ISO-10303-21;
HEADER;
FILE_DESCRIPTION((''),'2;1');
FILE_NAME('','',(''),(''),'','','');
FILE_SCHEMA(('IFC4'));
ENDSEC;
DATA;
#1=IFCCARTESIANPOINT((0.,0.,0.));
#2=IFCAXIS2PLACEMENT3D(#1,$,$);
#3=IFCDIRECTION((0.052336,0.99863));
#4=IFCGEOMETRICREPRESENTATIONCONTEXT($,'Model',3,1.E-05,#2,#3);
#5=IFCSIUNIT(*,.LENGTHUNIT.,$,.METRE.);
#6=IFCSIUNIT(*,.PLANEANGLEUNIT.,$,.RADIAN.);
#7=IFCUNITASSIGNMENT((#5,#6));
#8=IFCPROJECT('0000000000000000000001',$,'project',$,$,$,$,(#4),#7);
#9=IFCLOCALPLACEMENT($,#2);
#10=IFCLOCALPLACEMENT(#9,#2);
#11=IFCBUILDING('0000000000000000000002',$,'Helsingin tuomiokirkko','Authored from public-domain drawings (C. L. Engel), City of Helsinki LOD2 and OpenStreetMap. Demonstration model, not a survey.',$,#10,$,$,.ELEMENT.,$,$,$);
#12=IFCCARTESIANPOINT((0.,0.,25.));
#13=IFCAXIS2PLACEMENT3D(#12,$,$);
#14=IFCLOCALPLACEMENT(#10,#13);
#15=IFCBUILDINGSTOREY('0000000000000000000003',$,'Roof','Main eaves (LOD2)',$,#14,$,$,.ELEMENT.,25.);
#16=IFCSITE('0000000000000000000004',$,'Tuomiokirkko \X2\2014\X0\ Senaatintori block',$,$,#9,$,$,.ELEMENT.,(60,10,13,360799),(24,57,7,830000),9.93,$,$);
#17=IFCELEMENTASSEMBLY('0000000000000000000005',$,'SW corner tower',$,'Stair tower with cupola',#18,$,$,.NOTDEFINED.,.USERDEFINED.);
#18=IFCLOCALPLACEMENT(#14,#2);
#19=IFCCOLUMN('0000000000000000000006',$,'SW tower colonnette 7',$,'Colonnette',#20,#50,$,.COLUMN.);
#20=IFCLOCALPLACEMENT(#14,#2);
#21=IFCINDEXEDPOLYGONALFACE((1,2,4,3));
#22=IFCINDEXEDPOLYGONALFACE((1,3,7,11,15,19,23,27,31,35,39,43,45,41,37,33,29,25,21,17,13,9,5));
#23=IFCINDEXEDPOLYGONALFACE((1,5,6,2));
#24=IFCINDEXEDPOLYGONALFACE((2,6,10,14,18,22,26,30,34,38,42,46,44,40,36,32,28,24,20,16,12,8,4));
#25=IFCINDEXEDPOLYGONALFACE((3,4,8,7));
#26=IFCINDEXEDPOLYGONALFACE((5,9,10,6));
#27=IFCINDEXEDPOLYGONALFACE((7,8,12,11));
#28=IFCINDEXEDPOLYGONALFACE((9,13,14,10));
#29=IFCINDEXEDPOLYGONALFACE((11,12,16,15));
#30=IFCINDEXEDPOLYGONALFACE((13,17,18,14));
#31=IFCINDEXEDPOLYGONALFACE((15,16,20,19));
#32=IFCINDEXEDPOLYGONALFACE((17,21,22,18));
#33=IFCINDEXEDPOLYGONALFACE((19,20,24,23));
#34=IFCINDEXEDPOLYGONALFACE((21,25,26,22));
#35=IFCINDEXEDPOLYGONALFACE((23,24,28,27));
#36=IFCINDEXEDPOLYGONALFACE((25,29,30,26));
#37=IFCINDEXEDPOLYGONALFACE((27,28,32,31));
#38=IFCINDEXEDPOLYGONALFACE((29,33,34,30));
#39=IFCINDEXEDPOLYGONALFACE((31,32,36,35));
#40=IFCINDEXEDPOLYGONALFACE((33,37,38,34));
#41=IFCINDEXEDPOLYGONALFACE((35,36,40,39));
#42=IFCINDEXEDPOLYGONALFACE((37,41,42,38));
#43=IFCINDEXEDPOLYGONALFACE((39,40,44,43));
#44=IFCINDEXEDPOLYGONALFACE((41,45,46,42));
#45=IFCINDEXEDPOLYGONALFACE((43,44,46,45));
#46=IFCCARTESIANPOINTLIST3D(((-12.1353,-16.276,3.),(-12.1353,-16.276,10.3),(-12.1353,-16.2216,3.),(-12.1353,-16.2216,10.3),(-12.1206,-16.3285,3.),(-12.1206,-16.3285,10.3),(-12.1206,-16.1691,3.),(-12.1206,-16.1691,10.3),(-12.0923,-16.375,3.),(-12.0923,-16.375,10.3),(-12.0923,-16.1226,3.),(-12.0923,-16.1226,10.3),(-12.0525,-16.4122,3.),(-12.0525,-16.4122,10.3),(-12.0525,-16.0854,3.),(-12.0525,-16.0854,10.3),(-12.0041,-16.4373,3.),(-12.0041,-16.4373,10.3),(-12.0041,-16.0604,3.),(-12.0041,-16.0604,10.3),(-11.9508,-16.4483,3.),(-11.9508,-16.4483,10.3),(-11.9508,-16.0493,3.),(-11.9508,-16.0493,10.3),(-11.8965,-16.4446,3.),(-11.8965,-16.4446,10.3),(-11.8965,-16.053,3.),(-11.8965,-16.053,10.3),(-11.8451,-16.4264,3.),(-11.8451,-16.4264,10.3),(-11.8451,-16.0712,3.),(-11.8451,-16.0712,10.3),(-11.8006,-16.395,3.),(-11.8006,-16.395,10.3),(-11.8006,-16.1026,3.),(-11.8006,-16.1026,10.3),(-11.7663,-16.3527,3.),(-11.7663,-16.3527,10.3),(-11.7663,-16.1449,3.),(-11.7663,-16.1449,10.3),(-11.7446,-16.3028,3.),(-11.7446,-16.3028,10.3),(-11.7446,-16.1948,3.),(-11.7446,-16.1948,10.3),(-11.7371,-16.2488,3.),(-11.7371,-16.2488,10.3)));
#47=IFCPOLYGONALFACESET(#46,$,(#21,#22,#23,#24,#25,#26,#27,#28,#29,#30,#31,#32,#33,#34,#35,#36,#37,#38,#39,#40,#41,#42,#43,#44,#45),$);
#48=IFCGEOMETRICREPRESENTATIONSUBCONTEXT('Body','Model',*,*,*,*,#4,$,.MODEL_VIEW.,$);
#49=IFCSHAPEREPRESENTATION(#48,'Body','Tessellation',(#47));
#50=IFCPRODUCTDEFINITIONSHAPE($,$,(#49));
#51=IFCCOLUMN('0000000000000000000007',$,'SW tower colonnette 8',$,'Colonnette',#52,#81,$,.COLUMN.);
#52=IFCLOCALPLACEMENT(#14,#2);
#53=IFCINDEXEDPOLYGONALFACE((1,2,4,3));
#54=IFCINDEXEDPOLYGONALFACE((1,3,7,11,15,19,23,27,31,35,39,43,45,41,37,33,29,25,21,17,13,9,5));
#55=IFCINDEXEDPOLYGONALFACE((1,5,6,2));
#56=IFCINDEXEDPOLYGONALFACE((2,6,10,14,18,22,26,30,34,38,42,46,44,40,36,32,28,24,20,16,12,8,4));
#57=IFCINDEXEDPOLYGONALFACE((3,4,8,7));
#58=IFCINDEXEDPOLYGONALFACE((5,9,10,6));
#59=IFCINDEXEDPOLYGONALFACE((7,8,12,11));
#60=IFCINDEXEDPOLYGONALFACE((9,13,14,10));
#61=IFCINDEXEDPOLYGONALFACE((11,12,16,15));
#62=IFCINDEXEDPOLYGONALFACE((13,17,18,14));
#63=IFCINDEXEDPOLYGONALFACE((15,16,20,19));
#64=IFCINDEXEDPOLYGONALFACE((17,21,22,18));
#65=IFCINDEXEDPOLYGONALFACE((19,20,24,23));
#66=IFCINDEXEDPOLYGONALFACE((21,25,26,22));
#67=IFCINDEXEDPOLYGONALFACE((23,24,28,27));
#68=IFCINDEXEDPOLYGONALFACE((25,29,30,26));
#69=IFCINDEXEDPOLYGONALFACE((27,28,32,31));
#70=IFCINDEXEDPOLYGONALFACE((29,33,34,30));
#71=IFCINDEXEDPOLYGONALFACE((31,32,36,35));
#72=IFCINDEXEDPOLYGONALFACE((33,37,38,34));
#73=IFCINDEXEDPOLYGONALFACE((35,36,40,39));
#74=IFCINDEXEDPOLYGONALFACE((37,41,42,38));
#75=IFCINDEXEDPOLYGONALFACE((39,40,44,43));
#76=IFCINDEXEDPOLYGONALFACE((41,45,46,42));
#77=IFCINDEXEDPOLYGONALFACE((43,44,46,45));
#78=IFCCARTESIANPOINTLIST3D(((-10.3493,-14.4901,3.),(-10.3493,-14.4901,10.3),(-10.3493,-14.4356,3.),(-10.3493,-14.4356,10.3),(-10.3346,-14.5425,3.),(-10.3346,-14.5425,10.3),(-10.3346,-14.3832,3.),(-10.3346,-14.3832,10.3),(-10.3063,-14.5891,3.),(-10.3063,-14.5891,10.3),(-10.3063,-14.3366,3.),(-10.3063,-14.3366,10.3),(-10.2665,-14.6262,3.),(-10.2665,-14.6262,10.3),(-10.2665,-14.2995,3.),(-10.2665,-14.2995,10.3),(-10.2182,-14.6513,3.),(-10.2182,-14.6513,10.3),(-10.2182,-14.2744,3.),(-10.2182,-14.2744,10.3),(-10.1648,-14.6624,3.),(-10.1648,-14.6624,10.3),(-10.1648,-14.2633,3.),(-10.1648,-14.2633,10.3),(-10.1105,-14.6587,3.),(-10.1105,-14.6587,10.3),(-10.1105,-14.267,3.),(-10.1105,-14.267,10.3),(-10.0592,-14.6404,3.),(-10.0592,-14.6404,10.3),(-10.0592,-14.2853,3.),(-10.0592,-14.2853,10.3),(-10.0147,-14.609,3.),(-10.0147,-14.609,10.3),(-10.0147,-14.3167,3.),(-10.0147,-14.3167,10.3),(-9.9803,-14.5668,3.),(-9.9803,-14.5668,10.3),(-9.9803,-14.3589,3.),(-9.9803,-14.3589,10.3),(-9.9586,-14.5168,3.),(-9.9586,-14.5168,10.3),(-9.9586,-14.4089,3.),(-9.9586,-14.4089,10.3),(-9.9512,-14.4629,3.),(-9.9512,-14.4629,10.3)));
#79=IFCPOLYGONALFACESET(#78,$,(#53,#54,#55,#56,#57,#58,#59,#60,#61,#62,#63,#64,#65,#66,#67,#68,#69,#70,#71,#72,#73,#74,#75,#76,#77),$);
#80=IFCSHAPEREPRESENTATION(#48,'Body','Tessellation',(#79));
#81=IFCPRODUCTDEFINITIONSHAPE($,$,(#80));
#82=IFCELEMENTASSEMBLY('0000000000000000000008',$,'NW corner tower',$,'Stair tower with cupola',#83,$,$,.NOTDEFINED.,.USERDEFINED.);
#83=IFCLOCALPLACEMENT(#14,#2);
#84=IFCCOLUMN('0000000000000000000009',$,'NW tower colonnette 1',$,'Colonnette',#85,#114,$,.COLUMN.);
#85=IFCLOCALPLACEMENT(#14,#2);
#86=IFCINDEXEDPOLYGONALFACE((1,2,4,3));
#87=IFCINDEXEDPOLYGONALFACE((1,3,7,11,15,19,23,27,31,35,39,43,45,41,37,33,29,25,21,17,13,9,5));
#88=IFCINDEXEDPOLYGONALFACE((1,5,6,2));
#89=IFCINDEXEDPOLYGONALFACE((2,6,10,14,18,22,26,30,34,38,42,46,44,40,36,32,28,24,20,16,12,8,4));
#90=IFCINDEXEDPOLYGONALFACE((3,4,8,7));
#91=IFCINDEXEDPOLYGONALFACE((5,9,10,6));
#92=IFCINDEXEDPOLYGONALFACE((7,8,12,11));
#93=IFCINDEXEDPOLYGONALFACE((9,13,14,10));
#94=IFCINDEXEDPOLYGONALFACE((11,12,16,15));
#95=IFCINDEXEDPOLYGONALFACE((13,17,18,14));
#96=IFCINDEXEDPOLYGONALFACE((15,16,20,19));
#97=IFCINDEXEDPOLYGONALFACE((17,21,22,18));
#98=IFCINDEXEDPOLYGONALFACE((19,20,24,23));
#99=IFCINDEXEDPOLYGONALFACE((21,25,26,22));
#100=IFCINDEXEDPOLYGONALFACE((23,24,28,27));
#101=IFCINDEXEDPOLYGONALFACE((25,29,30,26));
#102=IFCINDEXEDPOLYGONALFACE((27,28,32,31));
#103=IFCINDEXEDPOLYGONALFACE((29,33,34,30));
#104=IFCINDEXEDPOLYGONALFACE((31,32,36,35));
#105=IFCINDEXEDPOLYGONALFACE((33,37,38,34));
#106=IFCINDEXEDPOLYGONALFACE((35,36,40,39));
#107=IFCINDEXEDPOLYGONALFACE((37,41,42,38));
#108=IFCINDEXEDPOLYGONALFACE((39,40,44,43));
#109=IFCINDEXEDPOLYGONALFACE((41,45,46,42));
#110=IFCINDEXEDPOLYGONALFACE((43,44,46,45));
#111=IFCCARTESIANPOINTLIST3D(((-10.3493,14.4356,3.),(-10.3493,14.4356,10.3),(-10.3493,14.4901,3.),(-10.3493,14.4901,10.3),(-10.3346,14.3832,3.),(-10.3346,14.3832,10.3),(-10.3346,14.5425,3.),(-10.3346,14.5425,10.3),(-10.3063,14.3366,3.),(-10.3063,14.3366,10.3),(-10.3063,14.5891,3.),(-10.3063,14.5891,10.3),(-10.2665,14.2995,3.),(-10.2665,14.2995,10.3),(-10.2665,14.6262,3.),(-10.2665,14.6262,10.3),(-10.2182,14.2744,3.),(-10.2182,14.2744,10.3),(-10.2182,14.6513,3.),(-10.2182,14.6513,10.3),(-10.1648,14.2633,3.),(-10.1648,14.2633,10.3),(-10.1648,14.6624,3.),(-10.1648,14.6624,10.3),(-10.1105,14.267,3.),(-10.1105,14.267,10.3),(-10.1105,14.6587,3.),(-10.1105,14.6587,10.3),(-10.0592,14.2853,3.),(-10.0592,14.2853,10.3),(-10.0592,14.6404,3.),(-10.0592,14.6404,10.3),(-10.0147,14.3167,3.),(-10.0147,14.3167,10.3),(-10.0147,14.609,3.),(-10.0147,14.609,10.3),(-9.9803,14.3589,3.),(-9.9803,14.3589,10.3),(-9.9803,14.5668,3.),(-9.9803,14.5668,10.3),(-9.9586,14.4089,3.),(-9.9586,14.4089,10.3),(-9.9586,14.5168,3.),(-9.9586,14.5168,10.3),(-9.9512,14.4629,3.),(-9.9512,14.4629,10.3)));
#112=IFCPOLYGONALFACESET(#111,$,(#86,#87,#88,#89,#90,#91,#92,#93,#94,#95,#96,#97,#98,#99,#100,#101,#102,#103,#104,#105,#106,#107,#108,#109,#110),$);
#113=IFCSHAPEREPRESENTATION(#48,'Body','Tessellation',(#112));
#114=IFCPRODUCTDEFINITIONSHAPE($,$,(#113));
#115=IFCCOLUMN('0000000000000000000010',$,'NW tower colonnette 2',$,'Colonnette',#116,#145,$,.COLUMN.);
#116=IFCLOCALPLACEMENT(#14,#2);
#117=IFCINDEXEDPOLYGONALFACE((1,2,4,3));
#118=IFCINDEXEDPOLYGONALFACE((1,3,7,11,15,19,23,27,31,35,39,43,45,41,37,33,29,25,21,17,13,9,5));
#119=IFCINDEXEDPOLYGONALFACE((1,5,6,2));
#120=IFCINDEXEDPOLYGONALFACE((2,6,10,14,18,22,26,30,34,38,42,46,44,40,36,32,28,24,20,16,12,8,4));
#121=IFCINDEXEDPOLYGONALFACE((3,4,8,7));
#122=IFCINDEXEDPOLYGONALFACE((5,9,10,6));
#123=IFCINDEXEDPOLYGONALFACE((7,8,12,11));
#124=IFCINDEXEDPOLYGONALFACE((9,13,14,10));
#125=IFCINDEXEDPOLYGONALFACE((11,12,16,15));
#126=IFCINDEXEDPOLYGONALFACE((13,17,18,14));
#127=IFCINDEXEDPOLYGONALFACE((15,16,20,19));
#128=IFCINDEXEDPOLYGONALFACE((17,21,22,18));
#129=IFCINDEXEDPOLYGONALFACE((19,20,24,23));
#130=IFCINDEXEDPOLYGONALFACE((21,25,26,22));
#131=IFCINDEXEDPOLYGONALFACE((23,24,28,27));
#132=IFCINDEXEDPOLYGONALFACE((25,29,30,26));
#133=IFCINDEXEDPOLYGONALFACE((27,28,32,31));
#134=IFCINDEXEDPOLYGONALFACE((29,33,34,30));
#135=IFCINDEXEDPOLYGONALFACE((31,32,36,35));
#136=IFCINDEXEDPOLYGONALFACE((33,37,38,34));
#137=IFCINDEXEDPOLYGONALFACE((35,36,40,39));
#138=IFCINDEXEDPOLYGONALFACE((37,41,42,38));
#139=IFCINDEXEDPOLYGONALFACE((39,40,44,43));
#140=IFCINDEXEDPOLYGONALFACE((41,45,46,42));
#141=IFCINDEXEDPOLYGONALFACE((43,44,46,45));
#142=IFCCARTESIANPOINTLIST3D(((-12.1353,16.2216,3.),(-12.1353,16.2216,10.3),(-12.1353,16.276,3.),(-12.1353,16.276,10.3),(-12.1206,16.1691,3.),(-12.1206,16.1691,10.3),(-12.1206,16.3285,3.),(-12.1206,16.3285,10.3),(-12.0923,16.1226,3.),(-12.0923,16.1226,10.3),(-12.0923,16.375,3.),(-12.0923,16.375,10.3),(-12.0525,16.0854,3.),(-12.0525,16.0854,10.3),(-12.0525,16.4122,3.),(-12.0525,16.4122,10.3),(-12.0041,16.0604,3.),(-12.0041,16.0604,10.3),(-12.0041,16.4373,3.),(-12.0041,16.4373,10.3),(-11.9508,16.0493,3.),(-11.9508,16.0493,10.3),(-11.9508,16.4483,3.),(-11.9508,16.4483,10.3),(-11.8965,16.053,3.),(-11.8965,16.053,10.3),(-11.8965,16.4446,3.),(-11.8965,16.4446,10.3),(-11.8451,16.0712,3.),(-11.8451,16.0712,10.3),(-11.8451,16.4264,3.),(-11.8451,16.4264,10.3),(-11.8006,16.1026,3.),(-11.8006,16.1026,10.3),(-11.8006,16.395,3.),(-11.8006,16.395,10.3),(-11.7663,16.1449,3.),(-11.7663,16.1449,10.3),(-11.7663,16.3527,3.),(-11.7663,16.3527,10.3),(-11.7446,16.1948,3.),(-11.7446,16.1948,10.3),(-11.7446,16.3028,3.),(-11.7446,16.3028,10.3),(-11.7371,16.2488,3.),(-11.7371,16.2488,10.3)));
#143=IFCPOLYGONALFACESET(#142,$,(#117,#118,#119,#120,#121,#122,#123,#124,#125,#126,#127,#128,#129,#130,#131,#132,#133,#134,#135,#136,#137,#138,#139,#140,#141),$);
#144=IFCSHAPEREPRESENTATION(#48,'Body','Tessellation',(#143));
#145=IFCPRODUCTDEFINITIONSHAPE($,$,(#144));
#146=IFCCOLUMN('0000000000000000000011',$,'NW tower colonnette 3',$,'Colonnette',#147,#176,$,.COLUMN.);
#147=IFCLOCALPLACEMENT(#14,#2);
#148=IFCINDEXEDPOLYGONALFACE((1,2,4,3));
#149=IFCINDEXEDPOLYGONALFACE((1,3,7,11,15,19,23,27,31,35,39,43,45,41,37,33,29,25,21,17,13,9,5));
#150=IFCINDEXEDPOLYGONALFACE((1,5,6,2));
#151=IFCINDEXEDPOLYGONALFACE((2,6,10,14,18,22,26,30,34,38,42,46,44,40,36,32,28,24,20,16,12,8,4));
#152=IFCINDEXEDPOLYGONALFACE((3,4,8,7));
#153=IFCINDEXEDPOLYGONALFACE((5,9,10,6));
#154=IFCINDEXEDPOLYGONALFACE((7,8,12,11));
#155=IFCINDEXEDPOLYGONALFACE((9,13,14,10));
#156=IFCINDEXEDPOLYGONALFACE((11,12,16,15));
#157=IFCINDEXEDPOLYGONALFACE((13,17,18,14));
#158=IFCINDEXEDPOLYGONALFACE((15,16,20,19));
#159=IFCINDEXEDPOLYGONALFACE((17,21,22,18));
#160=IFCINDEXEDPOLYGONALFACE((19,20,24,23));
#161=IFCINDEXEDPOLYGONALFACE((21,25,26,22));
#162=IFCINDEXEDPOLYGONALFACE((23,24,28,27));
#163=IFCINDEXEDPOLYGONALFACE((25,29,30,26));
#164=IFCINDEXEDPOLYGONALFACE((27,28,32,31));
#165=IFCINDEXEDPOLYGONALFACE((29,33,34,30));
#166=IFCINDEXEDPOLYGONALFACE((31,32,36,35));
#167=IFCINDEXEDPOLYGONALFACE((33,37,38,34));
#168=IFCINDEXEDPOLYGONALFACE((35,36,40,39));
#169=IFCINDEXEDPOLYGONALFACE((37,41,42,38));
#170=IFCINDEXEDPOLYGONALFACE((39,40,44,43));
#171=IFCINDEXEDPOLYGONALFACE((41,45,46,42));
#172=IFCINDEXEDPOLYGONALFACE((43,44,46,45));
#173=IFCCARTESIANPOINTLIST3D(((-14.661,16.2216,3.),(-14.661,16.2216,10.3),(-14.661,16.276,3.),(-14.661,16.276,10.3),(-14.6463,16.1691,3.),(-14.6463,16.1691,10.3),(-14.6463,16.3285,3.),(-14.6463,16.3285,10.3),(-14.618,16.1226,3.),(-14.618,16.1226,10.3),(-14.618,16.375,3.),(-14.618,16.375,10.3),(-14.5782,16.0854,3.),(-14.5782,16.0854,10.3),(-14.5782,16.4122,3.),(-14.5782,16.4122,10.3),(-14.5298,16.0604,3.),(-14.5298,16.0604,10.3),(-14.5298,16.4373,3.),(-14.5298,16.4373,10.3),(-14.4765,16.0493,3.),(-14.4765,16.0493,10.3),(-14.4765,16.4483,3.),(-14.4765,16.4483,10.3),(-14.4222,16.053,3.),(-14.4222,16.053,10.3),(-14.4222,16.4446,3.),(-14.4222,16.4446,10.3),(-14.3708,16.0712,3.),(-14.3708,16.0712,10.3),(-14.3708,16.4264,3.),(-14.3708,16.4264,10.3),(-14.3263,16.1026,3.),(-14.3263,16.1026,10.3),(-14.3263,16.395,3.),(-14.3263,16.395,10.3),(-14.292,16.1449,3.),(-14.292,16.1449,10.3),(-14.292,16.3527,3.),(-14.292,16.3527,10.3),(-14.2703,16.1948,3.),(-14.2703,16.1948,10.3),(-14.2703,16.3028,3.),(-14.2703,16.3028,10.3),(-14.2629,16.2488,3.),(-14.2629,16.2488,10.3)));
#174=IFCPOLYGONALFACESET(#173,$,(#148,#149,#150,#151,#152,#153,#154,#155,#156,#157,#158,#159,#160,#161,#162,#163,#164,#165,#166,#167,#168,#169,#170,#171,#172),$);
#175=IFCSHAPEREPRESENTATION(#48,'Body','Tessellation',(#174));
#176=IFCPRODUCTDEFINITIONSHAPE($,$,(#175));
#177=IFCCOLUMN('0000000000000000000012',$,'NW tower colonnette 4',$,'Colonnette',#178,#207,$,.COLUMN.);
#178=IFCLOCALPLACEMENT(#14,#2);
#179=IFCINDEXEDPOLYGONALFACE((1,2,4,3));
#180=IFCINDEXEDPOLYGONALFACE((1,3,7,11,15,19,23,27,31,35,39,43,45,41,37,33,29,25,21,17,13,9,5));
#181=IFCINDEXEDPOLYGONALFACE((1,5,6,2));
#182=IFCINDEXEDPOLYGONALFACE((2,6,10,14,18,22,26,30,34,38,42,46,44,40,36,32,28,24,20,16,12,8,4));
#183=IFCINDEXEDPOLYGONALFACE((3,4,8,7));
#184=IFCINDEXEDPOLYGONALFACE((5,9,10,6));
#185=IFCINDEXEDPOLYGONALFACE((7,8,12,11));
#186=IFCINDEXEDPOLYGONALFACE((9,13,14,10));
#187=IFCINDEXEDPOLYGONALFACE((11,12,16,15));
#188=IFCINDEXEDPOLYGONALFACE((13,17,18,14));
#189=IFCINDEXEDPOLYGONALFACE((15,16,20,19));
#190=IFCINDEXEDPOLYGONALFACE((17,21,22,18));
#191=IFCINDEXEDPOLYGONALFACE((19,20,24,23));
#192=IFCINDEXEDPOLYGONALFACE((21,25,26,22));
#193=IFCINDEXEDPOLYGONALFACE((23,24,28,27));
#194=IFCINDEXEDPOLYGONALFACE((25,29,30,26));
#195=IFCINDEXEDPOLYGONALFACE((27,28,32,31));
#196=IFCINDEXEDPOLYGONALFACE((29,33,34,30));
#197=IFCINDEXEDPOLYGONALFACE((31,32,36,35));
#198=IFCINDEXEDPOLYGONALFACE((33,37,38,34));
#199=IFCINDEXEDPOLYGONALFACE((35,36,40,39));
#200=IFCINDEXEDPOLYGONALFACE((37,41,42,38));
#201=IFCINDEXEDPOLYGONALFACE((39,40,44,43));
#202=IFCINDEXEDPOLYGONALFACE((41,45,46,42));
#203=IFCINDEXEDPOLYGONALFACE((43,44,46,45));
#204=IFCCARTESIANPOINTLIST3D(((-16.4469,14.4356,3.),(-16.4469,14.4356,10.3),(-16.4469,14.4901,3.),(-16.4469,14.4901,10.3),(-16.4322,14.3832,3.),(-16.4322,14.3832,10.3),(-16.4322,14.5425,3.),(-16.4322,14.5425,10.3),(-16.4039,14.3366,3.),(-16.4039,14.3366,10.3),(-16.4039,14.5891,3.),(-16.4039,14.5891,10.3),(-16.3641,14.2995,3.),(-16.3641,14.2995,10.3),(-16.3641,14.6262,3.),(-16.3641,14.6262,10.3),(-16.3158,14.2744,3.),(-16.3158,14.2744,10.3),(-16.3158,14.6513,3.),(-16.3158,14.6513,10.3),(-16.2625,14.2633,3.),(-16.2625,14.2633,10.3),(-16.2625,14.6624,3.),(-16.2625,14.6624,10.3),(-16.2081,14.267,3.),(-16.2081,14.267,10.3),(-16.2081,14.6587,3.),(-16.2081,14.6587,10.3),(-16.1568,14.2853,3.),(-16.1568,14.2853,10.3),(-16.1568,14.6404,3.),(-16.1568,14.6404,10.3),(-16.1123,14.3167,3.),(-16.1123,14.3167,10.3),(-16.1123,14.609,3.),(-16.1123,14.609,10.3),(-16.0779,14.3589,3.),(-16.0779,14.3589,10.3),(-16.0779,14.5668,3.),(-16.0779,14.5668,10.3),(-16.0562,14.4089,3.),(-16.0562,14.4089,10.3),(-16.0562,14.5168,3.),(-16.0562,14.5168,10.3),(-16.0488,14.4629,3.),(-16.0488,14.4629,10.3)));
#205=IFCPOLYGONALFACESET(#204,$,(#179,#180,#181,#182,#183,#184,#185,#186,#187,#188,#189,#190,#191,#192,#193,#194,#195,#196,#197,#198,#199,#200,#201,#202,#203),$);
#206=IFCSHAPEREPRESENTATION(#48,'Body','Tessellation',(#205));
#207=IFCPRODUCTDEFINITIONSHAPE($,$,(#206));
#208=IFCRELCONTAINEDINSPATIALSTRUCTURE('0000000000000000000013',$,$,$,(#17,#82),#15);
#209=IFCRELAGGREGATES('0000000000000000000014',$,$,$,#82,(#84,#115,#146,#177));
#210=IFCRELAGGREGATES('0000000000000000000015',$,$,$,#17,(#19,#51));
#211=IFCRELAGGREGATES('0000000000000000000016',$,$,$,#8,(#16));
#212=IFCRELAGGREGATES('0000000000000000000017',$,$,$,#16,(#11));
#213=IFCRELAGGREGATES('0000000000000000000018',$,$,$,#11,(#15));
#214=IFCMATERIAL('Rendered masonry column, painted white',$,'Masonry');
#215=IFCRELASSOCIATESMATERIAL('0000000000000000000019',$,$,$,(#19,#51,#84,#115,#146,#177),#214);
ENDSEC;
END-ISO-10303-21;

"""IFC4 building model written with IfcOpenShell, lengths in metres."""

from ifc_helpers import new_model, si_unit, direction, frame, origin, origin_2d_with_axis, place, context, subcontext, project, spatial, circle, extrude, material, element, aggregate, save


model = new_model("IFC4")

# Units and contexts
model_context = context("Model", 3, precision=1e-05, world=origin(), true_north=direction((0.052336, 0.99863)))
body_context = subcontext(model_context, "Body", "Model", "MODEL_VIEW")
ifc_project = project(units=[si_unit("LENGTHUNIT", "METRE"), si_unit("PLANEANGLEUNIT", "RADIAN")], contexts=[model_context])

# Site, building, storey
site_placement = place(None, origin())
site = spatial("IfcSite", under=ifc_project, at=site_placement, Name="Tuomiokirkko — Senaatintori block", CompositionType="ELEMENT", RefLatitude=(60, 10, 13, 360799), RefLongitude=(24, 57, 7, 830000), RefElevation=9.93)
building_placement = place(site_placement, origin())
building = spatial("IfcBuilding", under=site, at=building_placement, Name="Helsingin tuomiokirkko", Description="Authored from public-domain drawings (C. L. Engel), City of Helsinki LOD2 and OpenStreetMap. Demonstration model, not a survey.", CompositionType="ELEMENT")
storey_placement = place(building_placement, frame((0.0, 0.0, 25.0)))
storey = spatial("IfcBuildingStorey", under=building, at=storey_placement, Name="Roof", Description="Main eaves (LOD2)", CompositionType="ELEMENT", Elevation=25.0)

# Element assemblies, columns
assembly_1_placement = place(building_placement, origin())
assembly_1 = element("IfcElementAssembly", 1, at=assembly_1_placement, inside=storey, Name="SW corner tower", ObjectType="Stair tower with cupola", AssemblyPlace="NOTDEFINED", PredefinedType="USERDEFINED")
ifc_material_1 = material(Name="Rendered masonry column, painted white", Category="Masonry")
column_1_placement = place(building_placement, origin())
column_1 = element("IfcColumn", 2, at=column_1_placement, material=ifc_material_1, Name="SW tower colonnette 7", ObjectType="Colonnette", PredefinedType="COLUMN", context=body_context, shape_type="SweptSolid", body=[
    extrude(circle(Radius=0.2, at=origin_2d_with_axis()), frame((-11.9371, -16.2488, 28.0)), (0.0, 0.0, 1.0), 7.3),
])
column_2_placement = place(building_placement, origin())
column_2 = element("IfcColumn", 3, at=column_2_placement, material=ifc_material_1, Name="SW tower colonnette 8", ObjectType="Colonnette", PredefinedType="COLUMN", context=body_context, shape_type="SweptSolid", body=[
    extrude(circle(Radius=0.2, at=origin_2d_with_axis()), frame((-10.1512, -14.4629, 28.0)), (0.0, 0.0, 1.0), 7.3),
])
assembly_2_placement = place(building_placement, origin())
assembly_2 = element("IfcElementAssembly", 4, at=assembly_2_placement, inside=storey, Name="NW corner tower", ObjectType="Stair tower with cupola", AssemblyPlace="NOTDEFINED", PredefinedType="USERDEFINED")
column_3_placement = place(building_placement, origin())
column_3 = element("IfcColumn", 5, at=column_3_placement, material=ifc_material_1, Name="NW tower colonnette 1", ObjectType="Colonnette", PredefinedType="COLUMN", context=body_context, shape_type="SweptSolid", body=[
    extrude(circle(Radius=0.2, at=origin_2d_with_axis()), frame((-10.1512, 14.4629, 28.0)), (0.0, 0.0, 1.0), 7.3),
])
column_4_placement = place(building_placement, origin())
column_4 = element("IfcColumn", 6, at=column_4_placement, material=ifc_material_1, Name="NW tower colonnette 2", ObjectType="Colonnette", PredefinedType="COLUMN", context=body_context, shape_type="SweptSolid", body=[
    extrude(circle(Radius=0.2, at=origin_2d_with_axis()), frame((-11.9371, 16.2488, 28.0)), (0.0, 0.0, 1.0), 7.3),
])
column_5_placement = place(building_placement, origin())
column_5 = element("IfcColumn", 7, at=column_5_placement, material=ifc_material_1, Name="NW tower colonnette 3", ObjectType="Colonnette", PredefinedType="COLUMN", context=body_context, shape_type="SweptSolid", body=[
    extrude(circle(Radius=0.2, at=origin_2d_with_axis()), frame((-14.4629, 16.2488, 28.0)), (0.0, 0.0, 1.0), 7.3),
])
column_6_placement = place(building_placement, origin())
column_6 = element("IfcColumn", 8, at=column_6_placement, material=ifc_material_1, Name="NW tower colonnette 4", ObjectType="Colonnette", PredefinedType="COLUMN", context=body_context, shape_type="SweptSolid", body=[
    extrude(circle(Radius=0.2, at=origin_2d_with_axis()), frame((-16.2488, 14.4629, 28.0)), (0.0, 0.0, 1.0), 7.3),
])

aggregate(assembly_2, [column_3, column_4, column_5, column_6])

aggregate(assembly_1, [column_1, column_2])

save(model, "model.ifc")
